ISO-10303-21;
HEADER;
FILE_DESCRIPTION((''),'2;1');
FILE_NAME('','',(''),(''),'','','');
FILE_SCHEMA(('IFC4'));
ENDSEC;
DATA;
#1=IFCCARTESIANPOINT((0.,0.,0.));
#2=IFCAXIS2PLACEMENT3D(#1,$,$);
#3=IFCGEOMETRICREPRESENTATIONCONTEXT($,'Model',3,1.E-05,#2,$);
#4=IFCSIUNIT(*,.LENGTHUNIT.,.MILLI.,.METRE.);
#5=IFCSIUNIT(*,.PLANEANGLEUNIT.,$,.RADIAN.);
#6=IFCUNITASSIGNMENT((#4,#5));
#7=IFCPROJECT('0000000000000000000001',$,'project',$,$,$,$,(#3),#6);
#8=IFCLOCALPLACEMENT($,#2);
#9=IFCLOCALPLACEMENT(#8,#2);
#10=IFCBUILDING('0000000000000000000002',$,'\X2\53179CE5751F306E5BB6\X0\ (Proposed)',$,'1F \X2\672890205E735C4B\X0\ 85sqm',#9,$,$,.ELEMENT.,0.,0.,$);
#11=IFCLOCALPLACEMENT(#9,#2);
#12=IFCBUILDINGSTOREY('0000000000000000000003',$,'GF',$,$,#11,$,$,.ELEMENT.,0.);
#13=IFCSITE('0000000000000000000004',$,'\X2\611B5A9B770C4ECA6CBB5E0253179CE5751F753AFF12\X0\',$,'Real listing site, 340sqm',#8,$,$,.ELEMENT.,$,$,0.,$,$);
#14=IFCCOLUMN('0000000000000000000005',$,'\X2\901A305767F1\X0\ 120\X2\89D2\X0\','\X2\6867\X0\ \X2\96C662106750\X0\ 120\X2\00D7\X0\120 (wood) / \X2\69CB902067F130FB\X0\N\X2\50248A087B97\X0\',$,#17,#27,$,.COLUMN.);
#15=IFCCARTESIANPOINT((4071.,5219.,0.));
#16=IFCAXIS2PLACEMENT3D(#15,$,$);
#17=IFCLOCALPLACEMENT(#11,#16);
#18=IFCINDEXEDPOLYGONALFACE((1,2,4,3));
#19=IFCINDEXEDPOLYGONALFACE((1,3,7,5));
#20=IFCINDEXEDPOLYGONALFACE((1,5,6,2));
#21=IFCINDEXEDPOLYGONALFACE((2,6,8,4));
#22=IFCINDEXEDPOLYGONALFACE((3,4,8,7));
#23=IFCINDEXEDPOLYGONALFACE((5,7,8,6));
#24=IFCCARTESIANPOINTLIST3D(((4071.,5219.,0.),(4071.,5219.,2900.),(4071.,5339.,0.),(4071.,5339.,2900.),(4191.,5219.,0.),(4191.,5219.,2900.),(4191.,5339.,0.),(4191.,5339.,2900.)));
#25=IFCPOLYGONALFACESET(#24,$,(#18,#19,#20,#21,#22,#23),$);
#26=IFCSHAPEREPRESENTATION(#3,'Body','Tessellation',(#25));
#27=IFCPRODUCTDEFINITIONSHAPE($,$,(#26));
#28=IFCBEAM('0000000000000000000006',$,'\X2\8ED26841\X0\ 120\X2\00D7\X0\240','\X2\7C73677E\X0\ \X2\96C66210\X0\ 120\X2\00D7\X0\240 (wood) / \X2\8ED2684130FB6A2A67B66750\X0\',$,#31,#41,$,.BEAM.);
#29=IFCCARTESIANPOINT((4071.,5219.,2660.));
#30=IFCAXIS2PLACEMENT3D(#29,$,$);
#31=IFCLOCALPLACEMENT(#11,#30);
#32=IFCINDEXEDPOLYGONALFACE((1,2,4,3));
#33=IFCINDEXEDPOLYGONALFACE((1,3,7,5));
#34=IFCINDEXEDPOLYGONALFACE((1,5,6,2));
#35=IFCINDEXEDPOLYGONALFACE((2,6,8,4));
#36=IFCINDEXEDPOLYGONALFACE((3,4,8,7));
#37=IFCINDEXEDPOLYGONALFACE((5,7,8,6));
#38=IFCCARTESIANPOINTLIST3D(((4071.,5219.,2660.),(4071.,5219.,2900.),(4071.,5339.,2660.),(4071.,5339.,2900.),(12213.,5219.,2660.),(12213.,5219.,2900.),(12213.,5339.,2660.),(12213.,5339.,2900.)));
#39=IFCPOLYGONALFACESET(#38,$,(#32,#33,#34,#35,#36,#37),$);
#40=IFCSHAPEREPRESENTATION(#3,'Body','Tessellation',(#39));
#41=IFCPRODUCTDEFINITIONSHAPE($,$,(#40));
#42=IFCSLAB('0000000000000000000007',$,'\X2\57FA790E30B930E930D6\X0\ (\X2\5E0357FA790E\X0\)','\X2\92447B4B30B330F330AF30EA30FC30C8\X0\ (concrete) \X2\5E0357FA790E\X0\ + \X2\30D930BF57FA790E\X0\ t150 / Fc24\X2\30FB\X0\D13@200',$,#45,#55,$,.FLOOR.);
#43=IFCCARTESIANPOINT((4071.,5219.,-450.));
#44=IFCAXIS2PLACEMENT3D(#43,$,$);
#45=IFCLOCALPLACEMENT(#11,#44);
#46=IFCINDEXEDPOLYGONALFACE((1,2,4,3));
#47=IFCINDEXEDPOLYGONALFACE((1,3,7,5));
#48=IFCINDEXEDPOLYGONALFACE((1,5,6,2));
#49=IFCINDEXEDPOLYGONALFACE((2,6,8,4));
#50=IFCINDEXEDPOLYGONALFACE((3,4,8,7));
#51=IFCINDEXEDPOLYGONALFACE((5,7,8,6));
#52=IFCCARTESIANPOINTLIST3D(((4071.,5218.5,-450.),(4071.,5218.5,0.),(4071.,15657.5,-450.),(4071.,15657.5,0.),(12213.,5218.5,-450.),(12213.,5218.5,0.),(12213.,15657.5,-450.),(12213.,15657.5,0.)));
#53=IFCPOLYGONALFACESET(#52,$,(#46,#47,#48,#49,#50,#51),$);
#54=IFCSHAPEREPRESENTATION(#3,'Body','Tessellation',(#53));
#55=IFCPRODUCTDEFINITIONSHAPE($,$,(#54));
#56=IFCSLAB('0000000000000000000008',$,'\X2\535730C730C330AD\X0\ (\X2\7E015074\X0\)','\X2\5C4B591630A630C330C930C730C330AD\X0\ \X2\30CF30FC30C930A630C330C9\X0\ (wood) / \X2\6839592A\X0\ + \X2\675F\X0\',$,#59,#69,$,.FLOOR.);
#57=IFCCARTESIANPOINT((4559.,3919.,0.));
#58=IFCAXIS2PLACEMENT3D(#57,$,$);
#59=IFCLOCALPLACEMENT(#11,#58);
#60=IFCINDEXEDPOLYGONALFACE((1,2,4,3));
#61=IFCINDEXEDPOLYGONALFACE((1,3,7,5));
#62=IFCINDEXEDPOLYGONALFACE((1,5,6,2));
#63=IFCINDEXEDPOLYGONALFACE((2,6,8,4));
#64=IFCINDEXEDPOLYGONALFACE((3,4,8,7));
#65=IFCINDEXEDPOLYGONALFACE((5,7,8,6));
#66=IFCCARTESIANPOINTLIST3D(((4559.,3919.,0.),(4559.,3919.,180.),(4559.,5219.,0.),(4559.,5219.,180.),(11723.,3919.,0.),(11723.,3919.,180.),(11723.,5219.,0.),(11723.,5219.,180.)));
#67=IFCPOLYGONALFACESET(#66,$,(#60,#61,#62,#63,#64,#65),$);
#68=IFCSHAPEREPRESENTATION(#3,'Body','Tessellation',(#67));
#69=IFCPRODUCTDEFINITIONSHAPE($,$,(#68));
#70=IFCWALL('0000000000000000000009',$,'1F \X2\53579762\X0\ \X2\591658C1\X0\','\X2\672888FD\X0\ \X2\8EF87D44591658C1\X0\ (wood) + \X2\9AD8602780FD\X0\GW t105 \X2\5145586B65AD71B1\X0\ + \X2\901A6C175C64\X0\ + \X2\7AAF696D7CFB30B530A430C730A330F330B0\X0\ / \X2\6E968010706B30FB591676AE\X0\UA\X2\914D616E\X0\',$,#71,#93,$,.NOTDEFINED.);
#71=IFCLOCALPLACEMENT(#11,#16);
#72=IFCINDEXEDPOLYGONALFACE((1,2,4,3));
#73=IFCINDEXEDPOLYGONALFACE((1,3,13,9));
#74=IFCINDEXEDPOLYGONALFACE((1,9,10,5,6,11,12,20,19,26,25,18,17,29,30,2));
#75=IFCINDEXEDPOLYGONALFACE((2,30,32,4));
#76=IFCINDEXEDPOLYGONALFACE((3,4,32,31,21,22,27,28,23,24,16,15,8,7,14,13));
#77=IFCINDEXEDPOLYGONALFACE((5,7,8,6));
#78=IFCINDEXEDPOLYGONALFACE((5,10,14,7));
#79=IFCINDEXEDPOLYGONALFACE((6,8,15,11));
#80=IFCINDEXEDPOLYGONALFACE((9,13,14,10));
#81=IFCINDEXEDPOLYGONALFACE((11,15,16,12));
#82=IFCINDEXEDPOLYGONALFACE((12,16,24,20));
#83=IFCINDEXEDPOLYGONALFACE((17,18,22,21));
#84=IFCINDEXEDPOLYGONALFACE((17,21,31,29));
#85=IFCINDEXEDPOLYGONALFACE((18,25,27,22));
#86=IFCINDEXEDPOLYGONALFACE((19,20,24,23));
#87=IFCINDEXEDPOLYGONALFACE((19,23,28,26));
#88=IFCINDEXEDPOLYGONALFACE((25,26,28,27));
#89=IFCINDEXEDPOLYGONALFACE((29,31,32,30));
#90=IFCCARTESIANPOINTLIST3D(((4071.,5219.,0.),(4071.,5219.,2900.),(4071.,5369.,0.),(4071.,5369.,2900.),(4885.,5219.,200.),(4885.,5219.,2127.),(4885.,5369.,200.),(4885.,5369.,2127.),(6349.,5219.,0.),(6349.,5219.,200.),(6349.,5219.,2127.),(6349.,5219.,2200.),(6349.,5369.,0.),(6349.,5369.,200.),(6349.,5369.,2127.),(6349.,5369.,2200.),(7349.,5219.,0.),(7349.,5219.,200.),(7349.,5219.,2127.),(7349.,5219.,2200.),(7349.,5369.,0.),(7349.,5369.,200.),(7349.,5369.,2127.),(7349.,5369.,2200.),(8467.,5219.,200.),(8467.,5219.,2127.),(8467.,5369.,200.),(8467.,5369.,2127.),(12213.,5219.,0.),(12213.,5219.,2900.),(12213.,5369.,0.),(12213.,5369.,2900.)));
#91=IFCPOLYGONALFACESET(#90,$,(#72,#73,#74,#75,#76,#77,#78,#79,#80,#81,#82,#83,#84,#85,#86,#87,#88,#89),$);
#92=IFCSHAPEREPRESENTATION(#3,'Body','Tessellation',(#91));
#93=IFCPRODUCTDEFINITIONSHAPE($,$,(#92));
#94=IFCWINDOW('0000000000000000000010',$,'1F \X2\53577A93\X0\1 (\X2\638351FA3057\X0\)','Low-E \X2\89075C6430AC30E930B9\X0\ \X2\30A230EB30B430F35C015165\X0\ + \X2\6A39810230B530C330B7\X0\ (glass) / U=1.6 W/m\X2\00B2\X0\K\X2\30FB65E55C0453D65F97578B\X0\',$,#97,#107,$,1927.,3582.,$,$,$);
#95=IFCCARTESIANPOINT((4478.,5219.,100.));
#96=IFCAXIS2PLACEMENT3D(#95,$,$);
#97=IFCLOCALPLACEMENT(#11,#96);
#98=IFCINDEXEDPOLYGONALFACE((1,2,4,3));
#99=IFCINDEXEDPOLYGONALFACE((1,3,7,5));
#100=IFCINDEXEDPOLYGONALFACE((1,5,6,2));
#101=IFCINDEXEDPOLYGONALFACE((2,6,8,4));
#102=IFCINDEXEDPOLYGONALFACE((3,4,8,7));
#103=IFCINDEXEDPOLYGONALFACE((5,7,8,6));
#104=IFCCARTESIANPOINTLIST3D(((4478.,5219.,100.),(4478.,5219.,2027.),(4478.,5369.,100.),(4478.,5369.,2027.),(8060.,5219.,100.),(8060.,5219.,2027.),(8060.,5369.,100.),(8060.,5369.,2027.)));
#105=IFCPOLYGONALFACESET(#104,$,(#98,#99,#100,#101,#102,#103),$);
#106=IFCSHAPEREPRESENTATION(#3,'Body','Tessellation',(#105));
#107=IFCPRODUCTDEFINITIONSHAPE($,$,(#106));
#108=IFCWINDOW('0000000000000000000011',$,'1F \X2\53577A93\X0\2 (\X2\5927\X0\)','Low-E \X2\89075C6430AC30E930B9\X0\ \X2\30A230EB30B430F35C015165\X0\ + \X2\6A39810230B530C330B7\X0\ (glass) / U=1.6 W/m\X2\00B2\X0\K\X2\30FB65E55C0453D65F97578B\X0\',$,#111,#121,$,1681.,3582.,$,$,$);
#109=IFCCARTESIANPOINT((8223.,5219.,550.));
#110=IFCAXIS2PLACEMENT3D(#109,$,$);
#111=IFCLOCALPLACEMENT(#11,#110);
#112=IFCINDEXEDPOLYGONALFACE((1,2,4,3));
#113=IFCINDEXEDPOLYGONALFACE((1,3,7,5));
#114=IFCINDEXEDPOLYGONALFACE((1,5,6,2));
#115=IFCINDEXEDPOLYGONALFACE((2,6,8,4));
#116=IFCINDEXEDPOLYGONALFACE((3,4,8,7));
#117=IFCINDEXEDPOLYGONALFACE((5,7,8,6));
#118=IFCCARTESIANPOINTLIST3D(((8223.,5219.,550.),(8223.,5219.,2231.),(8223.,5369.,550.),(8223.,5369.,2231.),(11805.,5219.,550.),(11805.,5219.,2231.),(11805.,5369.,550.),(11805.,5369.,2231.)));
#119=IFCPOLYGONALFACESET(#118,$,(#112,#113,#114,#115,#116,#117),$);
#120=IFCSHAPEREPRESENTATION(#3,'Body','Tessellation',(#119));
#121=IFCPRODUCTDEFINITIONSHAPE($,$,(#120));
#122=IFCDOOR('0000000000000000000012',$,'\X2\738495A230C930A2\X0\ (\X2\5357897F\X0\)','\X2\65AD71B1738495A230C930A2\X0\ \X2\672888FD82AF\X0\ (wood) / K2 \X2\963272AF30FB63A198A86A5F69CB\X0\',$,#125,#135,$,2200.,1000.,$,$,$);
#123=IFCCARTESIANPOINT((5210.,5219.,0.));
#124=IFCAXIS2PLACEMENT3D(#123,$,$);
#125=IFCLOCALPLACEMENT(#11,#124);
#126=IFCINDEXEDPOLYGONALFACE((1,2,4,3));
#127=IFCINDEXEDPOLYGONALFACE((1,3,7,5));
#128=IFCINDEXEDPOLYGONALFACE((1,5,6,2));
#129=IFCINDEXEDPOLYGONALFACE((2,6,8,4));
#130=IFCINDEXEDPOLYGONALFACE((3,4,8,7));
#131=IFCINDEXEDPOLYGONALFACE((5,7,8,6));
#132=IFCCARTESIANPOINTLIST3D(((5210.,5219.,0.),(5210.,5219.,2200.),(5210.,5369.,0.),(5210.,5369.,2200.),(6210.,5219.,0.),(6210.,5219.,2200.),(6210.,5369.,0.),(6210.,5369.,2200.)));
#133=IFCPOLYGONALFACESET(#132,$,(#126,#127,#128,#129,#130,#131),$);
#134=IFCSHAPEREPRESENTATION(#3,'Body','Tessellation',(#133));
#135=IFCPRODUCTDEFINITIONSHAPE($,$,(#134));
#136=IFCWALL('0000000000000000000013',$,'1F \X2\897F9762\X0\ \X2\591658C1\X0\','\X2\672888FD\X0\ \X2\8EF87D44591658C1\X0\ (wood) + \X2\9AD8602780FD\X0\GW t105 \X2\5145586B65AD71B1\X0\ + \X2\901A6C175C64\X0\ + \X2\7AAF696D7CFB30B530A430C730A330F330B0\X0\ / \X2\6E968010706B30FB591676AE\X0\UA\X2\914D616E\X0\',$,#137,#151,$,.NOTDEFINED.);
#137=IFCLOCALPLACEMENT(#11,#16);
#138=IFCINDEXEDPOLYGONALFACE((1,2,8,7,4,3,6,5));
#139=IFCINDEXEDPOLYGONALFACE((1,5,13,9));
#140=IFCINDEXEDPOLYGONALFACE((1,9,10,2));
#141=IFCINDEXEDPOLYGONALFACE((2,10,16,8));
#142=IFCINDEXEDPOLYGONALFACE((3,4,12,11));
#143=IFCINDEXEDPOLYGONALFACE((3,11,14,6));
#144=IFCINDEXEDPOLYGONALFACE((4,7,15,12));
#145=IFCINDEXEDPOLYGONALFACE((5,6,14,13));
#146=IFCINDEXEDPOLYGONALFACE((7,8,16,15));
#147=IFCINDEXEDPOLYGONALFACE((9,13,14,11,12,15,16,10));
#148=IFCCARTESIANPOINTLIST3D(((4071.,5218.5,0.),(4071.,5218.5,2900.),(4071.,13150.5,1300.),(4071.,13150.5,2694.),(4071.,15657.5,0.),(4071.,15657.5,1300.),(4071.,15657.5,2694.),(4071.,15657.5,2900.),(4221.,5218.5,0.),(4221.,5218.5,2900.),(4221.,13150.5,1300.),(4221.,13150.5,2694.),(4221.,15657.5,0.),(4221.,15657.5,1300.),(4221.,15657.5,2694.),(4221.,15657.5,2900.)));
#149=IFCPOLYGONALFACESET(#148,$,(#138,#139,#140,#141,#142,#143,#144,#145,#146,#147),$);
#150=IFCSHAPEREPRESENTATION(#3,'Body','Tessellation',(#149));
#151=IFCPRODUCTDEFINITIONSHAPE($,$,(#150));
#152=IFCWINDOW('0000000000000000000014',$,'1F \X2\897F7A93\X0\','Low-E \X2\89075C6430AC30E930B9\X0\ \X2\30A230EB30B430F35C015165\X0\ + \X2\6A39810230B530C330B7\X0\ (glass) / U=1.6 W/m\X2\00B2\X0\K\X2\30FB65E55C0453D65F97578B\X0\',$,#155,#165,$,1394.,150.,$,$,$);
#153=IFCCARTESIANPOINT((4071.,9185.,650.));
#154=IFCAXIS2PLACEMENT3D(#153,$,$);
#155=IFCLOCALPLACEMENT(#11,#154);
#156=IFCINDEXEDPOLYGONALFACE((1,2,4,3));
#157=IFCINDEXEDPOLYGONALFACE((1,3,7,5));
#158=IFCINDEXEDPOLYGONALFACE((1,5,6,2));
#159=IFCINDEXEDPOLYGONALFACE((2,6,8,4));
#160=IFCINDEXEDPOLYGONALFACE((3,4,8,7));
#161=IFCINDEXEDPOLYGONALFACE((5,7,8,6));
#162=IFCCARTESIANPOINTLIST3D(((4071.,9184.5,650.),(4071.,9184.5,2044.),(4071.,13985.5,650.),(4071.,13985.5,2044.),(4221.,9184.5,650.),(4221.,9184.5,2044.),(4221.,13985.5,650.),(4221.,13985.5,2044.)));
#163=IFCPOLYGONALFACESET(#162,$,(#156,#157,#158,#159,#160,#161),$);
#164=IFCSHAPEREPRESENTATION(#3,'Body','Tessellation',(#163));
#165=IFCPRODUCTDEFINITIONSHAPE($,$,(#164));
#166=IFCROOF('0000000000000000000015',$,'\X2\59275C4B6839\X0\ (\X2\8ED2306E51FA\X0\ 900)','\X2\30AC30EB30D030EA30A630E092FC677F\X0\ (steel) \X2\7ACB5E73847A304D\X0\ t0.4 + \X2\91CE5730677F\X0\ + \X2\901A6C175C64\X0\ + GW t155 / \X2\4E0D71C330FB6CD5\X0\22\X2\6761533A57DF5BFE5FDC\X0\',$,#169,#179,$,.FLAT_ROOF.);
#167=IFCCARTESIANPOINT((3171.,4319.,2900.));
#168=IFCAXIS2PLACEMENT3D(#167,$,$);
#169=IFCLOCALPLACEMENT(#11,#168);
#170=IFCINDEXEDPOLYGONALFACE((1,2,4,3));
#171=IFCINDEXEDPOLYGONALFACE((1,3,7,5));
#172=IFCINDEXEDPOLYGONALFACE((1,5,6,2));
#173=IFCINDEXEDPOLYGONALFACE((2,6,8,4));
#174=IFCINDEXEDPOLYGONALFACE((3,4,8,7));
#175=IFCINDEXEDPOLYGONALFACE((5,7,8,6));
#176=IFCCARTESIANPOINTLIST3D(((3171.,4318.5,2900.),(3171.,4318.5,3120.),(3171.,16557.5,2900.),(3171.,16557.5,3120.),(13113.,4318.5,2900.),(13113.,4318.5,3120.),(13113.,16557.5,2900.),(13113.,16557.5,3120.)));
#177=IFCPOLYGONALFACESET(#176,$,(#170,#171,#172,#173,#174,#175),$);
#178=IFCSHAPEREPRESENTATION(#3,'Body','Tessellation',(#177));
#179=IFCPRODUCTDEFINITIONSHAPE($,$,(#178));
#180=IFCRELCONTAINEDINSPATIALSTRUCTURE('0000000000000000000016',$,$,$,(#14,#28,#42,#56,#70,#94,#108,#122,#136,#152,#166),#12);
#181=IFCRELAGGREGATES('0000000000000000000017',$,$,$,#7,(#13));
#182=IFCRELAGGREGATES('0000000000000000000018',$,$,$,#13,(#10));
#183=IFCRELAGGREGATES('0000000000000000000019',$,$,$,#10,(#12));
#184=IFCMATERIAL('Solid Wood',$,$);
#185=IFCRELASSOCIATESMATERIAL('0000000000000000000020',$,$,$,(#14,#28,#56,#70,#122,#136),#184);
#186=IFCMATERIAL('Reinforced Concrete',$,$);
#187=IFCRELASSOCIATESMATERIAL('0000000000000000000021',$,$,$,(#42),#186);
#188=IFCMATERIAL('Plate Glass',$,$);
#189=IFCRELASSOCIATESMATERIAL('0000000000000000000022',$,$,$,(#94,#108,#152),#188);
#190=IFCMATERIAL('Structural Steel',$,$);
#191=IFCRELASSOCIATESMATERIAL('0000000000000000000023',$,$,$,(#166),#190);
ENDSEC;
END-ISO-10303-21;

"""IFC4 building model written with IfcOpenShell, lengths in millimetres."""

from ifc_helpers import new_model, si_unit, frame, frame_2d, origin, place, context, project, spatial, rectangle, extrude, material, element, fill, save


model = new_model("IFC4")

# Units and contexts
model_context = context("Model", 3, precision=1e-05, world=origin())
ifc_project = project(units=[si_unit("LENGTHUNIT", "METRE", prefix="MILLI"), si_unit("PLANEANGLEUNIT", "RADIAN")], contexts=[model_context])

# Site, building, storey
site_placement = place(None, origin())
site = spatial("IfcSite", under=ifc_project, at=site_placement, Name="愛媛県今治市北鳥生町２", ObjectType="Real listing site, 340sqm", CompositionType="ELEMENT", RefElevation=0.0)
building_placement = place(site_placement, origin())
building = spatial("IfcBuilding", under=site, at=building_placement, Name="北鳥生の家 (Proposed)", ObjectType="1F 木造平屋 85sqm", CompositionType="ELEMENT", ElevationOfRefHeight=0.0, ElevationOfTerrain=0.0)
storey_placement = place(building_placement, origin())
storey = spatial("IfcBuildingStorey", under=building, at=storey_placement, Name="GF", CompositionType="ELEMENT", Elevation=0.0)

# Column
ifc_material_1 = material(Name="Solid Wood")
column_1_placement = place(storey_placement, frame((4071.0, 5219.0, 0.0)))
element("IfcColumn", 1, at=column_1_placement, inside=storey, material=ifc_material_1, Name="通し柱 120角", Description="桧 集成材 120×120 (wood) / 構造柱・N値計算", PredefinedType="COLUMN", context=model_context, shape_type="SweptSolid", body=[
    extrude(rectangle(XDim=120.0, YDim=120.0, at=frame_2d((60.0, 60.0))), frame((4071.0, 5219.0, 0.0)), (0.0, 0.0, 1.0), 2900.0),
])

# Beam
beam_1_placement = place(storey_placement, frame((4071.0, 5219.0, 2660.0)))
element("IfcBeam", 2, at=beam_1_placement, inside=storey, material=ifc_material_1, Name="軒桁 120×240", Description="米松 集成 120×240 (wood) / 軒桁・横架材", PredefinedType="BEAM", context=model_context, shape_type="SweptSolid", body=[
    extrude(rectangle(XDim=8142.0, YDim=120.0, at=frame_2d((4071.0, 60.0))), frame((4071.0, 5219.0, 2660.0)), (0.0, 0.0, 1.0), 240.0),
])

# Slabs
ifc_material_2 = material(Name="Reinforced Concrete")
slab_1_placement = place(storey_placement, frame((4071.0, 5219.0, -450.0)))
element("IfcSlab", 3, at=slab_1_placement, inside=storey, material=ifc_material_2, Name="基礎スラブ (布基礎)", Description="鉄筋コンクリート (concrete) 布基礎 + ベタ基礎 t150 / Fc24・D13@200", PredefinedType="FLOOR", context=model_context, shape_type="SweptSolid", body=[
    extrude(rectangle(XDim=8142.0, YDim=10439.0, at=frame_2d((4071.0, 5219.0))), frame((4071.0, 5219.0, -450.0)), (0.0, 0.0, 1.0), 450.0),
])
slab_2_placement = place(storey_placement, frame((4559.0, 3919.0, 0.0)))
element("IfcSlab", 4, at=slab_2_placement, inside=storey, material=ifc_material_1, Name="南デッキ (縁側)", Description="屋外ウッドデッキ ハードウッド (wood) / 根太 + 束", PredefinedType="FLOOR", context=model_context, shape_type="SweptSolid", body=[
    extrude(rectangle(XDim=7164.0, YDim=1300.0, at=frame_2d((3582.0, 650.0))), frame((4559.0, 3919.0, 0.0)), (0.0, 0.0, 1.0), 180.0),
])

# Wall, openings, windows, door
wall_1_placement = place(storey_placement, frame((4071.0, 5219.0, 0.0)))
wall_1 = element("IfcWall", 5, at=wall_1_placement, inside=storey, material=ifc_material_1, Name="1F 南面 外壁", Description="木製 軸組外壁 (wood) + 高性能GW t105 充填断熱 + 通気層 + 窯業系サイディング / 準耐火・外皮UA配慮", PredefinedType="NOTDEFINED", context=model_context, shape_type="SweptSolid", body=[
    extrude(rectangle(XDim=8142.0, YDim=150.0, at=frame_2d((4071.0, 75.0))), frame((4071.0, 5219.0, 0.0)), (0.0, 0.0, 1.0), 2900.0),
])
opening_1_placement = place(storey_placement, frame((4478.0, 5219.0, 100.0)))
opening_1 = element("IfcOpeningElement", 6, at=opening_1_placement, cuts=wall_1, PredefinedType="NOTDEFINED", context=model_context, shape_type="SweptSolid", body=[
    extrude(rectangle(XDim=3582.0, YDim=150.0, at=frame_2d((1791.0, 75.0))), frame((4478.0, 5219.0, 100.0)), (0.0, 0.0, 1.0), 1927.0),
])
opening_2_placement = place(storey_placement, frame((8223.0, 5219.0, 550.0)))
opening_2 = element("IfcOpeningElement", 7, at=opening_2_placement, cuts=wall_1, PredefinedType="NOTDEFINED", context=model_context, shape_type="SweptSolid", body=[
    extrude(rectangle(XDim=3582.0, YDim=150.0, at=frame_2d((1791.0, 75.0))), frame((8223.0, 5219.0, 550.0)), (0.0, 0.0, 1.0), 1681.0),
])
opening_3_placement = place(storey_placement, frame((5210.0, 5219.0, 0.0)))
opening_3 = element("IfcOpeningElement", 8, at=opening_3_placement, cuts=wall_1, PredefinedType="NOTDEFINED", context=model_context, shape_type="SweptSolid", body=[
    extrude(rectangle(XDim=1000.0, YDim=150.0, at=frame_2d((500.0, 75.0))), frame((5210.0, 5219.0, 0.0)), (0.0, 0.0, 1.0), 2200.0),
])
ifc_material_3 = material(Name="Plate Glass")
window_1_placement = place(storey_placement, frame((4478.0, 5219.0, 100.0)))
window_1 = element("IfcWindow", 9, at=window_1_placement, inside=storey, material=ifc_material_3, Name="1F 南窓1 (掃出し)", Description="Low-E 複層ガラス アルゴン封入 + 樹脂サッシ (glass) / U=1.6 W/m²K・日射取得型", OverallHeight=1927.0, OverallWidth=3582.0, context=model_context, shape_type="SweptSolid", body=[
    extrude(rectangle(XDim=3582.0, YDim=150.0, at=frame_2d((1791.0, 75.0))), frame((4478.0, 5219.0, 100.0)), (0.0, 0.0, 1.0), 1927.0),
])
fill(opening_1, window_1)
window_2_placement = place(storey_placement, frame((8223.0, 5219.0, 550.0)))
window_2 = element("IfcWindow", 10, at=window_2_placement, inside=storey, material=ifc_material_3, Name="1F 南窓2 (大)", Description="Low-E 複層ガラス アルゴン封入 + 樹脂サッシ (glass) / U=1.6 W/m²K・日射取得型", OverallHeight=1681.0, OverallWidth=3582.0, context=model_context, shape_type="SweptSolid", body=[
    extrude(rectangle(XDim=3582.0, YDim=150.0, at=frame_2d((1791.0, 75.0))), frame((8223.0, 5219.0, 550.0)), (0.0, 0.0, 1.0), 1681.0),
])
fill(opening_2, window_2)
door_placement = place(storey_placement, frame((5210.0, 5219.0, 0.0)))
door = element("IfcDoor", 11, at=door_placement, inside=storey, material=ifc_material_1, Name="玄関ドア (南西)", Description="断熱玄関ドア 木製芯 (wood) / K2 防犯・採風機構", OverallHeight=2200.0, OverallWidth=1000.0, context=model_context, shape_type="SweptSolid", body=[
    extrude(rectangle(XDim=1000.0, YDim=150.0, at=frame_2d((500.0, 75.0))), frame((5210.0, 5219.0, 0.0)), (0.0, 0.0, 1.0), 2200.0),
])
fill(opening_3, door)

# Wall, opening, window
wall_2_placement = place(storey_placement, frame((4071.0, 5219.0, 0.0)))
wall_2 = element("IfcWall", 12, at=wall_2_placement, inside=storey, material=ifc_material_1, Name="1F 西面 外壁", Description="木製 軸組外壁 (wood) + 高性能GW t105 充填断熱 + 通気層 + 窯業系サイディング / 準耐火・外皮UA配慮", PredefinedType="NOTDEFINED", context=model_context, shape_type="SweptSolid", body=[
    extrude(rectangle(XDim=150.0, YDim=10439.0, at=frame_2d((75.0, 5219.0))), frame((4071.0, 5219.0, 0.0)), (0.0, 0.0, 1.0), 2900.0),
])
opening_4_placement = place(storey_placement, frame((4071.0, 9185.0, 650.0)))
opening_4 = element("IfcOpeningElement", 13, at=opening_4_placement, cuts=wall_2, PredefinedType="NOTDEFINED", context=model_context, shape_type="SweptSolid", body=[
    extrude(rectangle(XDim=150.0, YDim=4801.0, at=frame_2d((75.0, 2400.0))), frame((4071.0, 9185.0, 650.0)), (0.0, 0.0, 1.0), 1394.0),
])
window_3_placement = place(storey_placement, frame((4071.0, 9185.0, 650.0)))
window_3 = element("IfcWindow", 14, at=window_3_placement, inside=storey, material=ifc_material_3, Name="1F 西窓", Description="Low-E 複層ガラス アルゴン封入 + 樹脂サッシ (glass) / U=1.6 W/m²K・日射取得型", OverallHeight=1394.0, OverallWidth=150.0, context=model_context, shape_type="SweptSolid", body=[
    extrude(rectangle(XDim=150.0, YDim=4801.0, at=frame_2d((75.0, 2400.0))), frame((4071.0, 9185.0, 650.0)), (0.0, 0.0, 1.0), 1394.0),
])
fill(opening_4, window_3)

# Roof
ifc_material_4 = material(Name="Structural Steel")
roof_placement = place(storey_placement, frame((3171.0, 4319.0, 2900.0)))
element("IfcRoof", 15, at=roof_placement, inside=storey, material=ifc_material_4, Name="大屋根 (軒の出 900)", Description="ガルバリウム鋼板 (steel) 立平葺き t0.4 + 野地板 + 通気層 + GW t155 / 不燃・法22条区域対応", PredefinedType="FLAT_ROOF", context=model_context, shape_type="SweptSolid", body=[
    extrude(rectangle(XDim=9942.0, YDim=12239.0, at=frame_2d((4971.0, 6119.0))), frame((3171.0, 4319.0, 2900.0)), (0.0, 0.0, 1.0), 220.0),
])

save(model, "model.ifc")
